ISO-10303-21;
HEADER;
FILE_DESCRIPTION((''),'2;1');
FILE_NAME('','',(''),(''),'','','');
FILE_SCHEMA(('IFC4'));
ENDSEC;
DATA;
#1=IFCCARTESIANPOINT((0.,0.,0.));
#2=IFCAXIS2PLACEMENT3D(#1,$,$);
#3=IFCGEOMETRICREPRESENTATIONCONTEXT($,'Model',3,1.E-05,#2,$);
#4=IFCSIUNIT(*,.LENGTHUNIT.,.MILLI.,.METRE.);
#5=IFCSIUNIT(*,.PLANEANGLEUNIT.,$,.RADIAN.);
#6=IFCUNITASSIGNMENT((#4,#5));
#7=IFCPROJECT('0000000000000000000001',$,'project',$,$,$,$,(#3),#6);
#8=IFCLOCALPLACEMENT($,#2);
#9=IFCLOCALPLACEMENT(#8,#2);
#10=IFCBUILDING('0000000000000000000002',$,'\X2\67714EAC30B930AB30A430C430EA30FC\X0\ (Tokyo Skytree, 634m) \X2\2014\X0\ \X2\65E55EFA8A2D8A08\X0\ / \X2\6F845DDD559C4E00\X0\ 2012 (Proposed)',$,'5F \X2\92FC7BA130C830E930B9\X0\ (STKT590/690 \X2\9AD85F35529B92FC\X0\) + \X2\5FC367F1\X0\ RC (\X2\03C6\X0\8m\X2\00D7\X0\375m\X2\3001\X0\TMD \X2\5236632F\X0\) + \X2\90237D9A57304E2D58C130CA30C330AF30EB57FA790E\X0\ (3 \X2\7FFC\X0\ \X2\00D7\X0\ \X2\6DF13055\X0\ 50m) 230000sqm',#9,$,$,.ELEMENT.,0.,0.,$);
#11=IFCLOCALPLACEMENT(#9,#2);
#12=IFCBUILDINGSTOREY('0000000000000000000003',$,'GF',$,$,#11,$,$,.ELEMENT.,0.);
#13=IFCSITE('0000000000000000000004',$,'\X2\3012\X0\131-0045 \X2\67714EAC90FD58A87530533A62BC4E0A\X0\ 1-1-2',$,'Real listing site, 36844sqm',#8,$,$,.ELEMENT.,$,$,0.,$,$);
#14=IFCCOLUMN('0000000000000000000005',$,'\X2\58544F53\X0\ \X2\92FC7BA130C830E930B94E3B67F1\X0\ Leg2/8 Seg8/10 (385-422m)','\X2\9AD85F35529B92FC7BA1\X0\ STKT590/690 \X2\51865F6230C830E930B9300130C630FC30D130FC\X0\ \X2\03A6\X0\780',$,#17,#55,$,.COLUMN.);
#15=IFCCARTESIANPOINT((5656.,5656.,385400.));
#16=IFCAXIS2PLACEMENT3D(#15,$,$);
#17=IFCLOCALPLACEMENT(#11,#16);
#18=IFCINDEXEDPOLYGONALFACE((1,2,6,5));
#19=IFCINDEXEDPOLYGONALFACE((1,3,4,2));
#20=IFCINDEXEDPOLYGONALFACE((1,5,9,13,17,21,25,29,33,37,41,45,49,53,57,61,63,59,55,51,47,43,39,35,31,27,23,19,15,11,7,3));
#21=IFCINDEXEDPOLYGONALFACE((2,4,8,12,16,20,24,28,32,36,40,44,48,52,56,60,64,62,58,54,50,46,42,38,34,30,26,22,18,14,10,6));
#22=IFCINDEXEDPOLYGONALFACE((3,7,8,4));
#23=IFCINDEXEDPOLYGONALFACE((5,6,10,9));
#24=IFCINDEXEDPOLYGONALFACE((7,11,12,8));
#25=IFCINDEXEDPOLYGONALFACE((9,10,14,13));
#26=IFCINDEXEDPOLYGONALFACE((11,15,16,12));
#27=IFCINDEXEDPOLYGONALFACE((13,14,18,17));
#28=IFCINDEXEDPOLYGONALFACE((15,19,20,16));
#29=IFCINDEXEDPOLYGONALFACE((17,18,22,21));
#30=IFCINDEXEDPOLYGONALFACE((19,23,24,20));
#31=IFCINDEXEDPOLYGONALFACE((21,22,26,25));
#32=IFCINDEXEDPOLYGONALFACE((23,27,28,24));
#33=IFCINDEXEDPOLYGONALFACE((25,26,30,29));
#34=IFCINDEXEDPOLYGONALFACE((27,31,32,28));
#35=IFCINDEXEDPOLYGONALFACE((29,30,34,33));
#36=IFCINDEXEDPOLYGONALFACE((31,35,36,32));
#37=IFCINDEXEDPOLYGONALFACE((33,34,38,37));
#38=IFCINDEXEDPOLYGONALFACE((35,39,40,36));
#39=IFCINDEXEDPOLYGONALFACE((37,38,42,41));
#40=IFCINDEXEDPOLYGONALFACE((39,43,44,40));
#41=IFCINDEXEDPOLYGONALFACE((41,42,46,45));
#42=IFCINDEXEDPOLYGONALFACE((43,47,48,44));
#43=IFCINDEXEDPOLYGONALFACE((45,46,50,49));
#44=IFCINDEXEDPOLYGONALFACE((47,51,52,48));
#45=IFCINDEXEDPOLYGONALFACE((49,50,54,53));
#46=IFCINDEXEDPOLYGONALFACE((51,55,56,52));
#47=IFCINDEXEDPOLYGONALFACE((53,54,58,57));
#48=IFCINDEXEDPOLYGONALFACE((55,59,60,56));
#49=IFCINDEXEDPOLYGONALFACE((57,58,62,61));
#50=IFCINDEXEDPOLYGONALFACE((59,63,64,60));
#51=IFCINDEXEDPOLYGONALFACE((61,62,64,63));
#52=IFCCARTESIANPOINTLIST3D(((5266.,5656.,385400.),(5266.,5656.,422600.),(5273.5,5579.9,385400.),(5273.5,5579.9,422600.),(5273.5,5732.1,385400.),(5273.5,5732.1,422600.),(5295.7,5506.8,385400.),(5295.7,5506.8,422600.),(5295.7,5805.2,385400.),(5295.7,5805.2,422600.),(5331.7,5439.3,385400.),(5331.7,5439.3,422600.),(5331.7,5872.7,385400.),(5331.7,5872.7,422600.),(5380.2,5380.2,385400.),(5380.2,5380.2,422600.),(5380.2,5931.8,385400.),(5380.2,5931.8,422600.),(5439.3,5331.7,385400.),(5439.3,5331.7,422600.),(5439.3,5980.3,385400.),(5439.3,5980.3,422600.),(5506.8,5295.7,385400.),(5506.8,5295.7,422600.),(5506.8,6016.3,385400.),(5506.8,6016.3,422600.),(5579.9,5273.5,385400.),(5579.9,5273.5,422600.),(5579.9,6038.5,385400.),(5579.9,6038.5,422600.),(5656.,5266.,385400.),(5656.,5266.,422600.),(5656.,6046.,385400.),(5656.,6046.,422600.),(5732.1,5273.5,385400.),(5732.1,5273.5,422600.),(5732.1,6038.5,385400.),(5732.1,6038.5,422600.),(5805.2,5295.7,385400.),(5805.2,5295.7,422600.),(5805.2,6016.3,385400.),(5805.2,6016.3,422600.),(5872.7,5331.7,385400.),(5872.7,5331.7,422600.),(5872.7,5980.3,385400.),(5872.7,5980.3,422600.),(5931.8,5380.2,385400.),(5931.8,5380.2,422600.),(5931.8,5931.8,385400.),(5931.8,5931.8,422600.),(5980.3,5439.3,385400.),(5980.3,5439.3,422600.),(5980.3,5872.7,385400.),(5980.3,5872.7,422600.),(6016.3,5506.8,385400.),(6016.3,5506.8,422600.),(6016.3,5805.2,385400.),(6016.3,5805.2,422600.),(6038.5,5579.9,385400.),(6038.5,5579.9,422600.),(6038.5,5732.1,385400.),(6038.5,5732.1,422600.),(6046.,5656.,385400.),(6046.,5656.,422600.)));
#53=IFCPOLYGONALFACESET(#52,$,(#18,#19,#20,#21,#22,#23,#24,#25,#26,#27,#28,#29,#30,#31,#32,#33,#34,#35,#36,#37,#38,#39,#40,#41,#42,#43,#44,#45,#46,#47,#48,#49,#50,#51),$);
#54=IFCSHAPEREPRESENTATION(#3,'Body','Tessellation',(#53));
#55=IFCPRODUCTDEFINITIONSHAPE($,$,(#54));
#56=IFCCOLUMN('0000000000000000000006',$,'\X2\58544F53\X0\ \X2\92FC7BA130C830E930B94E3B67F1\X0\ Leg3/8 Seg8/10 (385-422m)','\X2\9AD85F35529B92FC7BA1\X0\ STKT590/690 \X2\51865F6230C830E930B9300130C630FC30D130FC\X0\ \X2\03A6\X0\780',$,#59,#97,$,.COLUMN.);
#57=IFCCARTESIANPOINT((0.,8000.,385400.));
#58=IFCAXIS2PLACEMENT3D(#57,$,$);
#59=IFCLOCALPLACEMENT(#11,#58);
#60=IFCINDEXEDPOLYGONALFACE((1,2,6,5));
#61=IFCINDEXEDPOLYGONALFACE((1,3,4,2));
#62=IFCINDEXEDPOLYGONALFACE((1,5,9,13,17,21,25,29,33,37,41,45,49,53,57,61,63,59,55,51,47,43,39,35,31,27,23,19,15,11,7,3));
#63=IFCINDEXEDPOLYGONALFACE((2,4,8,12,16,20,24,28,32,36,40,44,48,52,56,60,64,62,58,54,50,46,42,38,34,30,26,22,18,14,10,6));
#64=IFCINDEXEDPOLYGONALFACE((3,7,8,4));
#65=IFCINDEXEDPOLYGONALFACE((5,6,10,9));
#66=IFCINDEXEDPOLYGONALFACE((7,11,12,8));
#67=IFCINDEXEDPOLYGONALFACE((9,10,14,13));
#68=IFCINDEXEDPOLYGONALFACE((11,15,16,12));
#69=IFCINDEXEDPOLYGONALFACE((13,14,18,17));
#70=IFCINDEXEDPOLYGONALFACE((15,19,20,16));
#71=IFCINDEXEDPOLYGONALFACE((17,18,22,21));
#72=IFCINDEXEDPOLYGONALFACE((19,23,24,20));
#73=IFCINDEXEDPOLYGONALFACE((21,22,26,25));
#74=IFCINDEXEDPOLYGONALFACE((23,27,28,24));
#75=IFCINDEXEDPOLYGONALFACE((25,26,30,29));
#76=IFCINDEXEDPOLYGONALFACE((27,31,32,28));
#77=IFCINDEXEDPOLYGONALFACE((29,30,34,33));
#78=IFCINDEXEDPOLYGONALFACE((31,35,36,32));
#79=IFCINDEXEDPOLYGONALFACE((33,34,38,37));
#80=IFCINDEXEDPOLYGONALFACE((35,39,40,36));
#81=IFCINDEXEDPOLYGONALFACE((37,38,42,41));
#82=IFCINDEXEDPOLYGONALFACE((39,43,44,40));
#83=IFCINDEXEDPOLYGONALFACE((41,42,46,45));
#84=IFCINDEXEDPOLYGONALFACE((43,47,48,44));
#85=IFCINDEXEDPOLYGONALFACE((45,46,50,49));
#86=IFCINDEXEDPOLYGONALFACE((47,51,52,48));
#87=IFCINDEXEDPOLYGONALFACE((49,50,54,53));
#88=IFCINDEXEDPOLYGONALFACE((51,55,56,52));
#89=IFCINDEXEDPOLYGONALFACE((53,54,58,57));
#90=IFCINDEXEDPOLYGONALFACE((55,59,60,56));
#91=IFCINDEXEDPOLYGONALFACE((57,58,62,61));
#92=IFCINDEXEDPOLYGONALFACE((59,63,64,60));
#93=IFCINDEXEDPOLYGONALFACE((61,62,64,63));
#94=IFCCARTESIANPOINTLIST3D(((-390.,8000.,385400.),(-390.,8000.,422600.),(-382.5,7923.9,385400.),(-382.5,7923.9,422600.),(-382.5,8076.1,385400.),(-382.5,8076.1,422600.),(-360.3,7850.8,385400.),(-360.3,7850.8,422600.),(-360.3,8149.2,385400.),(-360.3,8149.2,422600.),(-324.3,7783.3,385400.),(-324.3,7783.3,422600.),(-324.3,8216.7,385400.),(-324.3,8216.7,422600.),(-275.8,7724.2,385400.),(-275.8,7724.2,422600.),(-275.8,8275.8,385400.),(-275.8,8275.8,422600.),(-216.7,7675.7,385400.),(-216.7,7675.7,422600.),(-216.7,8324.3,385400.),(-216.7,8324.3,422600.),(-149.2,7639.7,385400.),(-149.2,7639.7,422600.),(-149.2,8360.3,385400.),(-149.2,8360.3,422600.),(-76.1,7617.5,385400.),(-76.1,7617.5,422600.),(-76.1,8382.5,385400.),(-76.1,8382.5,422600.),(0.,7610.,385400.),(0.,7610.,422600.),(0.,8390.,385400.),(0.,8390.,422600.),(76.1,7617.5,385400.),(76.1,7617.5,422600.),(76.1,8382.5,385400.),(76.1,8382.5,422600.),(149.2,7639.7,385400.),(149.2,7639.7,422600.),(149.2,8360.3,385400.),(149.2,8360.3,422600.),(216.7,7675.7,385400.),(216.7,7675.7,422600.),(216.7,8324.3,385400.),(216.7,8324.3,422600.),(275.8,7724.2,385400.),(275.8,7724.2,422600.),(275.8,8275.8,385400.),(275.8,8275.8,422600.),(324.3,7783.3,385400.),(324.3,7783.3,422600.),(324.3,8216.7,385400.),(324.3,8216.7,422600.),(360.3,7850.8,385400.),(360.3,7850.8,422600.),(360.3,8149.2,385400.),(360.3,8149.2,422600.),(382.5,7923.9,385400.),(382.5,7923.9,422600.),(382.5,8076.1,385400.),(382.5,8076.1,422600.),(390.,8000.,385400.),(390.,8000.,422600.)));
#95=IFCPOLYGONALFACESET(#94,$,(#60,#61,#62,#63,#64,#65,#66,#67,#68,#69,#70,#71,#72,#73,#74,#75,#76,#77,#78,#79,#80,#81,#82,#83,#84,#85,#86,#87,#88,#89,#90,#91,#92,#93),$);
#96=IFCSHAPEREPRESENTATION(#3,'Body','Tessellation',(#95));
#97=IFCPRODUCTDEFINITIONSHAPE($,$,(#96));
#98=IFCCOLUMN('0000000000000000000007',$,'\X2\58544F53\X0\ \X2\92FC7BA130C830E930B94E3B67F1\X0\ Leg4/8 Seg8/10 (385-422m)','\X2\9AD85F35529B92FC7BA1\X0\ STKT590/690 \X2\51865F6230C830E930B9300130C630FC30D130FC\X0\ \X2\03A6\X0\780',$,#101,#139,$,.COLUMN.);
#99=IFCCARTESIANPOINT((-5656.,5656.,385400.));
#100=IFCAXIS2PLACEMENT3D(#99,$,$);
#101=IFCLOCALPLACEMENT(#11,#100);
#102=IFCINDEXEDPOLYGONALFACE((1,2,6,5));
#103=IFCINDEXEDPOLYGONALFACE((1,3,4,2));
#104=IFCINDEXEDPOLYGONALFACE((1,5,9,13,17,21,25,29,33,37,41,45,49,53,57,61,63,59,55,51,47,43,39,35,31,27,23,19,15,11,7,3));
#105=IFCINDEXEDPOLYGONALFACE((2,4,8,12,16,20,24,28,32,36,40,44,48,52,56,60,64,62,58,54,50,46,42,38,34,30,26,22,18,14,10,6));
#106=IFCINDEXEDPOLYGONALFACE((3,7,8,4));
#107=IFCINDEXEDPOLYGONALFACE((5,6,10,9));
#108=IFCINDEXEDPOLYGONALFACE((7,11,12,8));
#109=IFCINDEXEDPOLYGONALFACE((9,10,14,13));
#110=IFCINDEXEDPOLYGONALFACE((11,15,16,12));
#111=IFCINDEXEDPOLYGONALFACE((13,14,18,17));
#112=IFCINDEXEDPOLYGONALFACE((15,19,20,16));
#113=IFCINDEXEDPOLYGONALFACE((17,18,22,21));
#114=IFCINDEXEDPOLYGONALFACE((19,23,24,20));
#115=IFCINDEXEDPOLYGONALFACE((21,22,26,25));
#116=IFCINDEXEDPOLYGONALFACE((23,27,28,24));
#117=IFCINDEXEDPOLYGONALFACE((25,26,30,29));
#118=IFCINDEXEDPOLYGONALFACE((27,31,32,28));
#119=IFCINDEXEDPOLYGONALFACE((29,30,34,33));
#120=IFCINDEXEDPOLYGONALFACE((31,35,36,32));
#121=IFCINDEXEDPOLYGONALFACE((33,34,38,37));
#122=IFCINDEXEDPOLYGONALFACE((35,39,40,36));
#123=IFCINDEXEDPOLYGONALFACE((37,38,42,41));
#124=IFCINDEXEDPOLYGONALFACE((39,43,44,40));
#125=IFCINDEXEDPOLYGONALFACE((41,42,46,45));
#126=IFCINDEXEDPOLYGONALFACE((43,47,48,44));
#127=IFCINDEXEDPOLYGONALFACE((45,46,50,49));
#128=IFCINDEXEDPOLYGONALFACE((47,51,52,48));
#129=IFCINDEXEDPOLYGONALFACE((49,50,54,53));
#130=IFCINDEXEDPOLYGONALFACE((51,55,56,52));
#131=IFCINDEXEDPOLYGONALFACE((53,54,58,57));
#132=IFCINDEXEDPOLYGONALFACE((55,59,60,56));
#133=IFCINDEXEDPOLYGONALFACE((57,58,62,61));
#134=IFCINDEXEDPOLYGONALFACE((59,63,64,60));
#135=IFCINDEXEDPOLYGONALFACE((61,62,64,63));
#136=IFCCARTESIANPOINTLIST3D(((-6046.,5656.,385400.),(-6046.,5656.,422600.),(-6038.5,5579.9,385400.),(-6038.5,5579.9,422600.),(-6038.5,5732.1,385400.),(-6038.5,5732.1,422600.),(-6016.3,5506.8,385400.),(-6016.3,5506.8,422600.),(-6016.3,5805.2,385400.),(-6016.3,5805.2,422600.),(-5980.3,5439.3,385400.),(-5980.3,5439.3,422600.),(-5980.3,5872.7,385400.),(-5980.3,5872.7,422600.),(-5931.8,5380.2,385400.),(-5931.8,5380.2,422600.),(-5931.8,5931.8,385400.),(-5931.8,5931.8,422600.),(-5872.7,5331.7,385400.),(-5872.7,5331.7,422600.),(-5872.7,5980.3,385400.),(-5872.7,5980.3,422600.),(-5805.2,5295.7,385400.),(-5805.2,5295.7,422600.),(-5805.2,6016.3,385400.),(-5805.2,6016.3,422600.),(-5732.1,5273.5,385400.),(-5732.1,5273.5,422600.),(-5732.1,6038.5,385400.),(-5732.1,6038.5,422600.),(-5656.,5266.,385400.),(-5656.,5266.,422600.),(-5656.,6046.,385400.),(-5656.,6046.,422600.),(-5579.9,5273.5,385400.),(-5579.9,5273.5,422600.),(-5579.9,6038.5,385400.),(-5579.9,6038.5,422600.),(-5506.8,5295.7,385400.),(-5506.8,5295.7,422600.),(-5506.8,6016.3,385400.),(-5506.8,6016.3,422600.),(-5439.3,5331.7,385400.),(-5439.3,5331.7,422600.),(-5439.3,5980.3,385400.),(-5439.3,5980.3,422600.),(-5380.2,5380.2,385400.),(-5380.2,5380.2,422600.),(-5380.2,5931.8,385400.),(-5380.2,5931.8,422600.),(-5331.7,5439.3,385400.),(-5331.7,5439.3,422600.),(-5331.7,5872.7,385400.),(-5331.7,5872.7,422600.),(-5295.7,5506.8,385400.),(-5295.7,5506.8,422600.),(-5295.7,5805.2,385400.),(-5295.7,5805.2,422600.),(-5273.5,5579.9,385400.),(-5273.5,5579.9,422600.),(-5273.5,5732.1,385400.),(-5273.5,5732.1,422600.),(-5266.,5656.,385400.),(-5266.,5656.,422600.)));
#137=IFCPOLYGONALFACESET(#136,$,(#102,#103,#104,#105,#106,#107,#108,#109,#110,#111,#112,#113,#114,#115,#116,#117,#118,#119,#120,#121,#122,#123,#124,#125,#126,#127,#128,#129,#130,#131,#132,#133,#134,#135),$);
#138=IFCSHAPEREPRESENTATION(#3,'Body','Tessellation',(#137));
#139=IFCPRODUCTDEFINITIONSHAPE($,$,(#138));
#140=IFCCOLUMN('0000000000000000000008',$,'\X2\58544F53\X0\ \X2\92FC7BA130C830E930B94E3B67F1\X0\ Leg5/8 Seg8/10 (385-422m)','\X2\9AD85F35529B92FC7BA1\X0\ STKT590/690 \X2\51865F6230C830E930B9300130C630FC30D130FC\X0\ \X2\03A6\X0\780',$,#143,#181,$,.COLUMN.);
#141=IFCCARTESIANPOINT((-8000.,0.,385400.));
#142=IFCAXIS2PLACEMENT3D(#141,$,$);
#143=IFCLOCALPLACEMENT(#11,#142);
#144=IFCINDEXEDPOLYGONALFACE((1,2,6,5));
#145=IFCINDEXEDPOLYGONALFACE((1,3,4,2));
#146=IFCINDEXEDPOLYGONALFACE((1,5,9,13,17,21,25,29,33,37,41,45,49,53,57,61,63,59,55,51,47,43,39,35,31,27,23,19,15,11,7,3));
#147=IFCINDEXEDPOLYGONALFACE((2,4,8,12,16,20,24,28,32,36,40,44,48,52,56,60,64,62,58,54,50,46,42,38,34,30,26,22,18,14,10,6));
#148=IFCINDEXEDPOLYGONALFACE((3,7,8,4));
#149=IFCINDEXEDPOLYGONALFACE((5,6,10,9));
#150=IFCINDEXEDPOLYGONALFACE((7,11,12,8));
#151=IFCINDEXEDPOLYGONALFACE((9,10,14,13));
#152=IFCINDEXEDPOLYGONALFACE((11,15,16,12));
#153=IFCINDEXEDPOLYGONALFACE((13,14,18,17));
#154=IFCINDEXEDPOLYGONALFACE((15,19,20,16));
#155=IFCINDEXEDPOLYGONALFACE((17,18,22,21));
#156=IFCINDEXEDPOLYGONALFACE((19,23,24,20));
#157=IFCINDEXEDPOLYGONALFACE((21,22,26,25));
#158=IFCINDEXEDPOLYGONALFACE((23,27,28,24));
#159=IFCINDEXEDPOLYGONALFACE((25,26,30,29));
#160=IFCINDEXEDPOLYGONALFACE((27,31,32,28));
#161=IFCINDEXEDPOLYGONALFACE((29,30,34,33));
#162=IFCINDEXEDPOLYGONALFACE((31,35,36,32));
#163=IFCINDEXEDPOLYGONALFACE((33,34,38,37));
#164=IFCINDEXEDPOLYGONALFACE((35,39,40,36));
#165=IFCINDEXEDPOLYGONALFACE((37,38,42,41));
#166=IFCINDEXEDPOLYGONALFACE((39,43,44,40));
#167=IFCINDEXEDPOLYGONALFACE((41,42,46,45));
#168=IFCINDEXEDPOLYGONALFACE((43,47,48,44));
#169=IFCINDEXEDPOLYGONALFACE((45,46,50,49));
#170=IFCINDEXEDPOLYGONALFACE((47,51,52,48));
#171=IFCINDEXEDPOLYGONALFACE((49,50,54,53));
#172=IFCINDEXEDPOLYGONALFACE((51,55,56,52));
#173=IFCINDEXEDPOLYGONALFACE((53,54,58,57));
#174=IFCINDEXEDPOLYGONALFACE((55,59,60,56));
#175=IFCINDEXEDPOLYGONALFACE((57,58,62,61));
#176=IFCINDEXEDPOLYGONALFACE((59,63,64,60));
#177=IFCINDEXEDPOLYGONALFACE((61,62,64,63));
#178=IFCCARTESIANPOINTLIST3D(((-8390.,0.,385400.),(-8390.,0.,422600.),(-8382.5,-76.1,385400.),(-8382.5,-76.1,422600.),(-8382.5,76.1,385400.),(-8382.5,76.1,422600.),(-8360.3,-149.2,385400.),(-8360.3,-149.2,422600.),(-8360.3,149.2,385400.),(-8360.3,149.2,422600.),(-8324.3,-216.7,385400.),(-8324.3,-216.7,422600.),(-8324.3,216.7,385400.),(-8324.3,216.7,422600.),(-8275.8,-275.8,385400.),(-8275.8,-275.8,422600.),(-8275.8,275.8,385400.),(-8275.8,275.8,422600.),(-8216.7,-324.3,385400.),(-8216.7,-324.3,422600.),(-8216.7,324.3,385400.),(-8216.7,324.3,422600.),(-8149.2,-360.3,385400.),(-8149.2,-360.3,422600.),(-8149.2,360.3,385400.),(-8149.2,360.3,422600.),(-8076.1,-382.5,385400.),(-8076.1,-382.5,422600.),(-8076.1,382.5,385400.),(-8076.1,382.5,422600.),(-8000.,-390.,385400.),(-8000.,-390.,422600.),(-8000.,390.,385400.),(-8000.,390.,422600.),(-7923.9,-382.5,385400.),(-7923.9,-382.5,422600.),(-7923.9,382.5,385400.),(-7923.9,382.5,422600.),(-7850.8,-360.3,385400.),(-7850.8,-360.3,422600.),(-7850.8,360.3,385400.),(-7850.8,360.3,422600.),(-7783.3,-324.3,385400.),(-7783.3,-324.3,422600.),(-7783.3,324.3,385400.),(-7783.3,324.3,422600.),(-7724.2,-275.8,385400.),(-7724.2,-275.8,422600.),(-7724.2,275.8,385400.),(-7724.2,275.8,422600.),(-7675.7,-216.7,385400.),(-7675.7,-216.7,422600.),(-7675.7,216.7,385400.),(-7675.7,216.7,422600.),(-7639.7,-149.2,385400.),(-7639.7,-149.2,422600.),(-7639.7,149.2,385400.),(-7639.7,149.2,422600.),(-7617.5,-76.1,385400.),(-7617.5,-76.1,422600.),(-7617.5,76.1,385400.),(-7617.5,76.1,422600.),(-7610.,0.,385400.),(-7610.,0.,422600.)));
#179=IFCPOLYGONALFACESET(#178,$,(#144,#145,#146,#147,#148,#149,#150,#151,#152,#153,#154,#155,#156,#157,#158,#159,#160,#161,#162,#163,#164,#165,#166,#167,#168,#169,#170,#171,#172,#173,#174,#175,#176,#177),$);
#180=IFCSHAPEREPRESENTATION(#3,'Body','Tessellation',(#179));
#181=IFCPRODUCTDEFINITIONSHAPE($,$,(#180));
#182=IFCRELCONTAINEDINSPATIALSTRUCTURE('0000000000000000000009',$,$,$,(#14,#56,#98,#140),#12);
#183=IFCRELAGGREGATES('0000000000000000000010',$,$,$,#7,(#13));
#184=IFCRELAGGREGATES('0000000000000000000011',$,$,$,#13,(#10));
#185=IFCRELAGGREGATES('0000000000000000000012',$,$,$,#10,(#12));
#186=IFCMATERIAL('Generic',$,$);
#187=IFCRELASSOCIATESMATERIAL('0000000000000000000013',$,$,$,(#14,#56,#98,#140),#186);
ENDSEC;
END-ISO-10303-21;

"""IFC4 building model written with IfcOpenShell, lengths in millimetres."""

from ifc_helpers import new_model, si_unit, frame, origin, origin_2d, place, context, project, spatial, circle, extrude, material, element, save


model = new_model("IFC4")

# Units and contexts
model_context = context("Model", 3, precision=1e-05, world=origin())
ifc_project = project(units=[si_unit("LENGTHUNIT", "METRE", prefix="MILLI"), si_unit("PLANEANGLEUNIT", "RADIAN")], contexts=[model_context])

# Site, building, storey
site_placement = place(None, origin())
site = spatial("IfcSite", under=ifc_project, at=site_placement, Name="〒131-0045 東京都墨田区押上 1-1-2", ObjectType="Real listing site, 36844sqm", CompositionType="ELEMENT", RefElevation=0.0)
building_placement = place(site_placement, origin())
building = spatial("IfcBuilding", under=site, at=building_placement, Name="東京スカイツリー (Tokyo Skytree, 634m) — 日建設計 / 澄川喜一 2012 (Proposed)", ObjectType="5F 鋼管トラス (STKT590/690 高張力鋼) + 心柱 RC (φ8m×375m、TMD 制振) + 連続地中壁ナックル基礎 (3 翼 × 深さ 50m) 230000sqm", CompositionType="ELEMENT", ElevationOfRefHeight=0.0, ElevationOfTerrain=0.0)
storey_placement = place(building_placement, origin())
storey = spatial("IfcBuildingStorey", under=building, at=storey_placement, Name="GF", CompositionType="ELEMENT", Elevation=0.0)

# Columns
ifc_material_1 = material(Name="Generic")
column_1_placement = place(storey_placement, frame((5656.0, 5656.0, 385400.0)))
element("IfcColumn", 1, at=column_1_placement, inside=storey, material=ifc_material_1, Name="塔体 鋼管トラス主柱 Leg2/8 Seg8/10 (385-422m)", Description="高張力鋼管 STKT590/690 円形トラス、テーパー Φ780", PredefinedType="COLUMN", context=model_context, shape_type="SweptSolid", body=[
    extrude(circle(Radius=390.0, at=origin_2d()), frame((5656.0, 5656.0, 385400.0)), (0.0, 0.0, 1.0), 37200.0),
])
column_2_placement = place(storey_placement, frame((0.0, 8000.0, 385400.0)))
element("IfcColumn", 2, at=column_2_placement, inside=storey, material=ifc_material_1, Name="塔体 鋼管トラス主柱 Leg3/8 Seg8/10 (385-422m)", Description="高張力鋼管 STKT590/690 円形トラス、テーパー Φ780", PredefinedType="COLUMN", context=model_context, shape_type="SweptSolid", body=[
    extrude(circle(Radius=390.0, at=origin_2d()), frame((0.0, 8000.0, 385400.0)), (0.0, 0.0, 1.0), 37200.0),
])
column_3_placement = place(storey_placement, frame((-5656.0, 5656.0, 385400.0)))
element("IfcColumn", 3, at=column_3_placement, inside=storey, material=ifc_material_1, Name="塔体 鋼管トラス主柱 Leg4/8 Seg8/10 (385-422m)", Description="高張力鋼管 STKT590/690 円形トラス、テーパー Φ780", PredefinedType="COLUMN", context=model_context, shape_type="SweptSolid", body=[
    extrude(circle(Radius=390.0, at=origin_2d()), frame((-5656.0, 5656.0, 385400.0)), (0.0, 0.0, 1.0), 37200.0),
])
column_4_placement = place(storey_placement, frame((-8000.0, 0.0, 385400.0)))
element("IfcColumn", 4, at=column_4_placement, inside=storey, material=ifc_material_1, Name="塔体 鋼管トラス主柱 Leg5/8 Seg8/10 (385-422m)", Description="高張力鋼管 STKT590/690 円形トラス、テーパー Φ780", PredefinedType="COLUMN", context=model_context, shape_type="SweptSolid", body=[
    extrude(circle(Radius=390.0, at=origin_2d()), frame((-8000.0, 0.0, 385400.0)), (0.0, 0.0, 1.0), 37200.0),
])

save(model, "model.ifc")
